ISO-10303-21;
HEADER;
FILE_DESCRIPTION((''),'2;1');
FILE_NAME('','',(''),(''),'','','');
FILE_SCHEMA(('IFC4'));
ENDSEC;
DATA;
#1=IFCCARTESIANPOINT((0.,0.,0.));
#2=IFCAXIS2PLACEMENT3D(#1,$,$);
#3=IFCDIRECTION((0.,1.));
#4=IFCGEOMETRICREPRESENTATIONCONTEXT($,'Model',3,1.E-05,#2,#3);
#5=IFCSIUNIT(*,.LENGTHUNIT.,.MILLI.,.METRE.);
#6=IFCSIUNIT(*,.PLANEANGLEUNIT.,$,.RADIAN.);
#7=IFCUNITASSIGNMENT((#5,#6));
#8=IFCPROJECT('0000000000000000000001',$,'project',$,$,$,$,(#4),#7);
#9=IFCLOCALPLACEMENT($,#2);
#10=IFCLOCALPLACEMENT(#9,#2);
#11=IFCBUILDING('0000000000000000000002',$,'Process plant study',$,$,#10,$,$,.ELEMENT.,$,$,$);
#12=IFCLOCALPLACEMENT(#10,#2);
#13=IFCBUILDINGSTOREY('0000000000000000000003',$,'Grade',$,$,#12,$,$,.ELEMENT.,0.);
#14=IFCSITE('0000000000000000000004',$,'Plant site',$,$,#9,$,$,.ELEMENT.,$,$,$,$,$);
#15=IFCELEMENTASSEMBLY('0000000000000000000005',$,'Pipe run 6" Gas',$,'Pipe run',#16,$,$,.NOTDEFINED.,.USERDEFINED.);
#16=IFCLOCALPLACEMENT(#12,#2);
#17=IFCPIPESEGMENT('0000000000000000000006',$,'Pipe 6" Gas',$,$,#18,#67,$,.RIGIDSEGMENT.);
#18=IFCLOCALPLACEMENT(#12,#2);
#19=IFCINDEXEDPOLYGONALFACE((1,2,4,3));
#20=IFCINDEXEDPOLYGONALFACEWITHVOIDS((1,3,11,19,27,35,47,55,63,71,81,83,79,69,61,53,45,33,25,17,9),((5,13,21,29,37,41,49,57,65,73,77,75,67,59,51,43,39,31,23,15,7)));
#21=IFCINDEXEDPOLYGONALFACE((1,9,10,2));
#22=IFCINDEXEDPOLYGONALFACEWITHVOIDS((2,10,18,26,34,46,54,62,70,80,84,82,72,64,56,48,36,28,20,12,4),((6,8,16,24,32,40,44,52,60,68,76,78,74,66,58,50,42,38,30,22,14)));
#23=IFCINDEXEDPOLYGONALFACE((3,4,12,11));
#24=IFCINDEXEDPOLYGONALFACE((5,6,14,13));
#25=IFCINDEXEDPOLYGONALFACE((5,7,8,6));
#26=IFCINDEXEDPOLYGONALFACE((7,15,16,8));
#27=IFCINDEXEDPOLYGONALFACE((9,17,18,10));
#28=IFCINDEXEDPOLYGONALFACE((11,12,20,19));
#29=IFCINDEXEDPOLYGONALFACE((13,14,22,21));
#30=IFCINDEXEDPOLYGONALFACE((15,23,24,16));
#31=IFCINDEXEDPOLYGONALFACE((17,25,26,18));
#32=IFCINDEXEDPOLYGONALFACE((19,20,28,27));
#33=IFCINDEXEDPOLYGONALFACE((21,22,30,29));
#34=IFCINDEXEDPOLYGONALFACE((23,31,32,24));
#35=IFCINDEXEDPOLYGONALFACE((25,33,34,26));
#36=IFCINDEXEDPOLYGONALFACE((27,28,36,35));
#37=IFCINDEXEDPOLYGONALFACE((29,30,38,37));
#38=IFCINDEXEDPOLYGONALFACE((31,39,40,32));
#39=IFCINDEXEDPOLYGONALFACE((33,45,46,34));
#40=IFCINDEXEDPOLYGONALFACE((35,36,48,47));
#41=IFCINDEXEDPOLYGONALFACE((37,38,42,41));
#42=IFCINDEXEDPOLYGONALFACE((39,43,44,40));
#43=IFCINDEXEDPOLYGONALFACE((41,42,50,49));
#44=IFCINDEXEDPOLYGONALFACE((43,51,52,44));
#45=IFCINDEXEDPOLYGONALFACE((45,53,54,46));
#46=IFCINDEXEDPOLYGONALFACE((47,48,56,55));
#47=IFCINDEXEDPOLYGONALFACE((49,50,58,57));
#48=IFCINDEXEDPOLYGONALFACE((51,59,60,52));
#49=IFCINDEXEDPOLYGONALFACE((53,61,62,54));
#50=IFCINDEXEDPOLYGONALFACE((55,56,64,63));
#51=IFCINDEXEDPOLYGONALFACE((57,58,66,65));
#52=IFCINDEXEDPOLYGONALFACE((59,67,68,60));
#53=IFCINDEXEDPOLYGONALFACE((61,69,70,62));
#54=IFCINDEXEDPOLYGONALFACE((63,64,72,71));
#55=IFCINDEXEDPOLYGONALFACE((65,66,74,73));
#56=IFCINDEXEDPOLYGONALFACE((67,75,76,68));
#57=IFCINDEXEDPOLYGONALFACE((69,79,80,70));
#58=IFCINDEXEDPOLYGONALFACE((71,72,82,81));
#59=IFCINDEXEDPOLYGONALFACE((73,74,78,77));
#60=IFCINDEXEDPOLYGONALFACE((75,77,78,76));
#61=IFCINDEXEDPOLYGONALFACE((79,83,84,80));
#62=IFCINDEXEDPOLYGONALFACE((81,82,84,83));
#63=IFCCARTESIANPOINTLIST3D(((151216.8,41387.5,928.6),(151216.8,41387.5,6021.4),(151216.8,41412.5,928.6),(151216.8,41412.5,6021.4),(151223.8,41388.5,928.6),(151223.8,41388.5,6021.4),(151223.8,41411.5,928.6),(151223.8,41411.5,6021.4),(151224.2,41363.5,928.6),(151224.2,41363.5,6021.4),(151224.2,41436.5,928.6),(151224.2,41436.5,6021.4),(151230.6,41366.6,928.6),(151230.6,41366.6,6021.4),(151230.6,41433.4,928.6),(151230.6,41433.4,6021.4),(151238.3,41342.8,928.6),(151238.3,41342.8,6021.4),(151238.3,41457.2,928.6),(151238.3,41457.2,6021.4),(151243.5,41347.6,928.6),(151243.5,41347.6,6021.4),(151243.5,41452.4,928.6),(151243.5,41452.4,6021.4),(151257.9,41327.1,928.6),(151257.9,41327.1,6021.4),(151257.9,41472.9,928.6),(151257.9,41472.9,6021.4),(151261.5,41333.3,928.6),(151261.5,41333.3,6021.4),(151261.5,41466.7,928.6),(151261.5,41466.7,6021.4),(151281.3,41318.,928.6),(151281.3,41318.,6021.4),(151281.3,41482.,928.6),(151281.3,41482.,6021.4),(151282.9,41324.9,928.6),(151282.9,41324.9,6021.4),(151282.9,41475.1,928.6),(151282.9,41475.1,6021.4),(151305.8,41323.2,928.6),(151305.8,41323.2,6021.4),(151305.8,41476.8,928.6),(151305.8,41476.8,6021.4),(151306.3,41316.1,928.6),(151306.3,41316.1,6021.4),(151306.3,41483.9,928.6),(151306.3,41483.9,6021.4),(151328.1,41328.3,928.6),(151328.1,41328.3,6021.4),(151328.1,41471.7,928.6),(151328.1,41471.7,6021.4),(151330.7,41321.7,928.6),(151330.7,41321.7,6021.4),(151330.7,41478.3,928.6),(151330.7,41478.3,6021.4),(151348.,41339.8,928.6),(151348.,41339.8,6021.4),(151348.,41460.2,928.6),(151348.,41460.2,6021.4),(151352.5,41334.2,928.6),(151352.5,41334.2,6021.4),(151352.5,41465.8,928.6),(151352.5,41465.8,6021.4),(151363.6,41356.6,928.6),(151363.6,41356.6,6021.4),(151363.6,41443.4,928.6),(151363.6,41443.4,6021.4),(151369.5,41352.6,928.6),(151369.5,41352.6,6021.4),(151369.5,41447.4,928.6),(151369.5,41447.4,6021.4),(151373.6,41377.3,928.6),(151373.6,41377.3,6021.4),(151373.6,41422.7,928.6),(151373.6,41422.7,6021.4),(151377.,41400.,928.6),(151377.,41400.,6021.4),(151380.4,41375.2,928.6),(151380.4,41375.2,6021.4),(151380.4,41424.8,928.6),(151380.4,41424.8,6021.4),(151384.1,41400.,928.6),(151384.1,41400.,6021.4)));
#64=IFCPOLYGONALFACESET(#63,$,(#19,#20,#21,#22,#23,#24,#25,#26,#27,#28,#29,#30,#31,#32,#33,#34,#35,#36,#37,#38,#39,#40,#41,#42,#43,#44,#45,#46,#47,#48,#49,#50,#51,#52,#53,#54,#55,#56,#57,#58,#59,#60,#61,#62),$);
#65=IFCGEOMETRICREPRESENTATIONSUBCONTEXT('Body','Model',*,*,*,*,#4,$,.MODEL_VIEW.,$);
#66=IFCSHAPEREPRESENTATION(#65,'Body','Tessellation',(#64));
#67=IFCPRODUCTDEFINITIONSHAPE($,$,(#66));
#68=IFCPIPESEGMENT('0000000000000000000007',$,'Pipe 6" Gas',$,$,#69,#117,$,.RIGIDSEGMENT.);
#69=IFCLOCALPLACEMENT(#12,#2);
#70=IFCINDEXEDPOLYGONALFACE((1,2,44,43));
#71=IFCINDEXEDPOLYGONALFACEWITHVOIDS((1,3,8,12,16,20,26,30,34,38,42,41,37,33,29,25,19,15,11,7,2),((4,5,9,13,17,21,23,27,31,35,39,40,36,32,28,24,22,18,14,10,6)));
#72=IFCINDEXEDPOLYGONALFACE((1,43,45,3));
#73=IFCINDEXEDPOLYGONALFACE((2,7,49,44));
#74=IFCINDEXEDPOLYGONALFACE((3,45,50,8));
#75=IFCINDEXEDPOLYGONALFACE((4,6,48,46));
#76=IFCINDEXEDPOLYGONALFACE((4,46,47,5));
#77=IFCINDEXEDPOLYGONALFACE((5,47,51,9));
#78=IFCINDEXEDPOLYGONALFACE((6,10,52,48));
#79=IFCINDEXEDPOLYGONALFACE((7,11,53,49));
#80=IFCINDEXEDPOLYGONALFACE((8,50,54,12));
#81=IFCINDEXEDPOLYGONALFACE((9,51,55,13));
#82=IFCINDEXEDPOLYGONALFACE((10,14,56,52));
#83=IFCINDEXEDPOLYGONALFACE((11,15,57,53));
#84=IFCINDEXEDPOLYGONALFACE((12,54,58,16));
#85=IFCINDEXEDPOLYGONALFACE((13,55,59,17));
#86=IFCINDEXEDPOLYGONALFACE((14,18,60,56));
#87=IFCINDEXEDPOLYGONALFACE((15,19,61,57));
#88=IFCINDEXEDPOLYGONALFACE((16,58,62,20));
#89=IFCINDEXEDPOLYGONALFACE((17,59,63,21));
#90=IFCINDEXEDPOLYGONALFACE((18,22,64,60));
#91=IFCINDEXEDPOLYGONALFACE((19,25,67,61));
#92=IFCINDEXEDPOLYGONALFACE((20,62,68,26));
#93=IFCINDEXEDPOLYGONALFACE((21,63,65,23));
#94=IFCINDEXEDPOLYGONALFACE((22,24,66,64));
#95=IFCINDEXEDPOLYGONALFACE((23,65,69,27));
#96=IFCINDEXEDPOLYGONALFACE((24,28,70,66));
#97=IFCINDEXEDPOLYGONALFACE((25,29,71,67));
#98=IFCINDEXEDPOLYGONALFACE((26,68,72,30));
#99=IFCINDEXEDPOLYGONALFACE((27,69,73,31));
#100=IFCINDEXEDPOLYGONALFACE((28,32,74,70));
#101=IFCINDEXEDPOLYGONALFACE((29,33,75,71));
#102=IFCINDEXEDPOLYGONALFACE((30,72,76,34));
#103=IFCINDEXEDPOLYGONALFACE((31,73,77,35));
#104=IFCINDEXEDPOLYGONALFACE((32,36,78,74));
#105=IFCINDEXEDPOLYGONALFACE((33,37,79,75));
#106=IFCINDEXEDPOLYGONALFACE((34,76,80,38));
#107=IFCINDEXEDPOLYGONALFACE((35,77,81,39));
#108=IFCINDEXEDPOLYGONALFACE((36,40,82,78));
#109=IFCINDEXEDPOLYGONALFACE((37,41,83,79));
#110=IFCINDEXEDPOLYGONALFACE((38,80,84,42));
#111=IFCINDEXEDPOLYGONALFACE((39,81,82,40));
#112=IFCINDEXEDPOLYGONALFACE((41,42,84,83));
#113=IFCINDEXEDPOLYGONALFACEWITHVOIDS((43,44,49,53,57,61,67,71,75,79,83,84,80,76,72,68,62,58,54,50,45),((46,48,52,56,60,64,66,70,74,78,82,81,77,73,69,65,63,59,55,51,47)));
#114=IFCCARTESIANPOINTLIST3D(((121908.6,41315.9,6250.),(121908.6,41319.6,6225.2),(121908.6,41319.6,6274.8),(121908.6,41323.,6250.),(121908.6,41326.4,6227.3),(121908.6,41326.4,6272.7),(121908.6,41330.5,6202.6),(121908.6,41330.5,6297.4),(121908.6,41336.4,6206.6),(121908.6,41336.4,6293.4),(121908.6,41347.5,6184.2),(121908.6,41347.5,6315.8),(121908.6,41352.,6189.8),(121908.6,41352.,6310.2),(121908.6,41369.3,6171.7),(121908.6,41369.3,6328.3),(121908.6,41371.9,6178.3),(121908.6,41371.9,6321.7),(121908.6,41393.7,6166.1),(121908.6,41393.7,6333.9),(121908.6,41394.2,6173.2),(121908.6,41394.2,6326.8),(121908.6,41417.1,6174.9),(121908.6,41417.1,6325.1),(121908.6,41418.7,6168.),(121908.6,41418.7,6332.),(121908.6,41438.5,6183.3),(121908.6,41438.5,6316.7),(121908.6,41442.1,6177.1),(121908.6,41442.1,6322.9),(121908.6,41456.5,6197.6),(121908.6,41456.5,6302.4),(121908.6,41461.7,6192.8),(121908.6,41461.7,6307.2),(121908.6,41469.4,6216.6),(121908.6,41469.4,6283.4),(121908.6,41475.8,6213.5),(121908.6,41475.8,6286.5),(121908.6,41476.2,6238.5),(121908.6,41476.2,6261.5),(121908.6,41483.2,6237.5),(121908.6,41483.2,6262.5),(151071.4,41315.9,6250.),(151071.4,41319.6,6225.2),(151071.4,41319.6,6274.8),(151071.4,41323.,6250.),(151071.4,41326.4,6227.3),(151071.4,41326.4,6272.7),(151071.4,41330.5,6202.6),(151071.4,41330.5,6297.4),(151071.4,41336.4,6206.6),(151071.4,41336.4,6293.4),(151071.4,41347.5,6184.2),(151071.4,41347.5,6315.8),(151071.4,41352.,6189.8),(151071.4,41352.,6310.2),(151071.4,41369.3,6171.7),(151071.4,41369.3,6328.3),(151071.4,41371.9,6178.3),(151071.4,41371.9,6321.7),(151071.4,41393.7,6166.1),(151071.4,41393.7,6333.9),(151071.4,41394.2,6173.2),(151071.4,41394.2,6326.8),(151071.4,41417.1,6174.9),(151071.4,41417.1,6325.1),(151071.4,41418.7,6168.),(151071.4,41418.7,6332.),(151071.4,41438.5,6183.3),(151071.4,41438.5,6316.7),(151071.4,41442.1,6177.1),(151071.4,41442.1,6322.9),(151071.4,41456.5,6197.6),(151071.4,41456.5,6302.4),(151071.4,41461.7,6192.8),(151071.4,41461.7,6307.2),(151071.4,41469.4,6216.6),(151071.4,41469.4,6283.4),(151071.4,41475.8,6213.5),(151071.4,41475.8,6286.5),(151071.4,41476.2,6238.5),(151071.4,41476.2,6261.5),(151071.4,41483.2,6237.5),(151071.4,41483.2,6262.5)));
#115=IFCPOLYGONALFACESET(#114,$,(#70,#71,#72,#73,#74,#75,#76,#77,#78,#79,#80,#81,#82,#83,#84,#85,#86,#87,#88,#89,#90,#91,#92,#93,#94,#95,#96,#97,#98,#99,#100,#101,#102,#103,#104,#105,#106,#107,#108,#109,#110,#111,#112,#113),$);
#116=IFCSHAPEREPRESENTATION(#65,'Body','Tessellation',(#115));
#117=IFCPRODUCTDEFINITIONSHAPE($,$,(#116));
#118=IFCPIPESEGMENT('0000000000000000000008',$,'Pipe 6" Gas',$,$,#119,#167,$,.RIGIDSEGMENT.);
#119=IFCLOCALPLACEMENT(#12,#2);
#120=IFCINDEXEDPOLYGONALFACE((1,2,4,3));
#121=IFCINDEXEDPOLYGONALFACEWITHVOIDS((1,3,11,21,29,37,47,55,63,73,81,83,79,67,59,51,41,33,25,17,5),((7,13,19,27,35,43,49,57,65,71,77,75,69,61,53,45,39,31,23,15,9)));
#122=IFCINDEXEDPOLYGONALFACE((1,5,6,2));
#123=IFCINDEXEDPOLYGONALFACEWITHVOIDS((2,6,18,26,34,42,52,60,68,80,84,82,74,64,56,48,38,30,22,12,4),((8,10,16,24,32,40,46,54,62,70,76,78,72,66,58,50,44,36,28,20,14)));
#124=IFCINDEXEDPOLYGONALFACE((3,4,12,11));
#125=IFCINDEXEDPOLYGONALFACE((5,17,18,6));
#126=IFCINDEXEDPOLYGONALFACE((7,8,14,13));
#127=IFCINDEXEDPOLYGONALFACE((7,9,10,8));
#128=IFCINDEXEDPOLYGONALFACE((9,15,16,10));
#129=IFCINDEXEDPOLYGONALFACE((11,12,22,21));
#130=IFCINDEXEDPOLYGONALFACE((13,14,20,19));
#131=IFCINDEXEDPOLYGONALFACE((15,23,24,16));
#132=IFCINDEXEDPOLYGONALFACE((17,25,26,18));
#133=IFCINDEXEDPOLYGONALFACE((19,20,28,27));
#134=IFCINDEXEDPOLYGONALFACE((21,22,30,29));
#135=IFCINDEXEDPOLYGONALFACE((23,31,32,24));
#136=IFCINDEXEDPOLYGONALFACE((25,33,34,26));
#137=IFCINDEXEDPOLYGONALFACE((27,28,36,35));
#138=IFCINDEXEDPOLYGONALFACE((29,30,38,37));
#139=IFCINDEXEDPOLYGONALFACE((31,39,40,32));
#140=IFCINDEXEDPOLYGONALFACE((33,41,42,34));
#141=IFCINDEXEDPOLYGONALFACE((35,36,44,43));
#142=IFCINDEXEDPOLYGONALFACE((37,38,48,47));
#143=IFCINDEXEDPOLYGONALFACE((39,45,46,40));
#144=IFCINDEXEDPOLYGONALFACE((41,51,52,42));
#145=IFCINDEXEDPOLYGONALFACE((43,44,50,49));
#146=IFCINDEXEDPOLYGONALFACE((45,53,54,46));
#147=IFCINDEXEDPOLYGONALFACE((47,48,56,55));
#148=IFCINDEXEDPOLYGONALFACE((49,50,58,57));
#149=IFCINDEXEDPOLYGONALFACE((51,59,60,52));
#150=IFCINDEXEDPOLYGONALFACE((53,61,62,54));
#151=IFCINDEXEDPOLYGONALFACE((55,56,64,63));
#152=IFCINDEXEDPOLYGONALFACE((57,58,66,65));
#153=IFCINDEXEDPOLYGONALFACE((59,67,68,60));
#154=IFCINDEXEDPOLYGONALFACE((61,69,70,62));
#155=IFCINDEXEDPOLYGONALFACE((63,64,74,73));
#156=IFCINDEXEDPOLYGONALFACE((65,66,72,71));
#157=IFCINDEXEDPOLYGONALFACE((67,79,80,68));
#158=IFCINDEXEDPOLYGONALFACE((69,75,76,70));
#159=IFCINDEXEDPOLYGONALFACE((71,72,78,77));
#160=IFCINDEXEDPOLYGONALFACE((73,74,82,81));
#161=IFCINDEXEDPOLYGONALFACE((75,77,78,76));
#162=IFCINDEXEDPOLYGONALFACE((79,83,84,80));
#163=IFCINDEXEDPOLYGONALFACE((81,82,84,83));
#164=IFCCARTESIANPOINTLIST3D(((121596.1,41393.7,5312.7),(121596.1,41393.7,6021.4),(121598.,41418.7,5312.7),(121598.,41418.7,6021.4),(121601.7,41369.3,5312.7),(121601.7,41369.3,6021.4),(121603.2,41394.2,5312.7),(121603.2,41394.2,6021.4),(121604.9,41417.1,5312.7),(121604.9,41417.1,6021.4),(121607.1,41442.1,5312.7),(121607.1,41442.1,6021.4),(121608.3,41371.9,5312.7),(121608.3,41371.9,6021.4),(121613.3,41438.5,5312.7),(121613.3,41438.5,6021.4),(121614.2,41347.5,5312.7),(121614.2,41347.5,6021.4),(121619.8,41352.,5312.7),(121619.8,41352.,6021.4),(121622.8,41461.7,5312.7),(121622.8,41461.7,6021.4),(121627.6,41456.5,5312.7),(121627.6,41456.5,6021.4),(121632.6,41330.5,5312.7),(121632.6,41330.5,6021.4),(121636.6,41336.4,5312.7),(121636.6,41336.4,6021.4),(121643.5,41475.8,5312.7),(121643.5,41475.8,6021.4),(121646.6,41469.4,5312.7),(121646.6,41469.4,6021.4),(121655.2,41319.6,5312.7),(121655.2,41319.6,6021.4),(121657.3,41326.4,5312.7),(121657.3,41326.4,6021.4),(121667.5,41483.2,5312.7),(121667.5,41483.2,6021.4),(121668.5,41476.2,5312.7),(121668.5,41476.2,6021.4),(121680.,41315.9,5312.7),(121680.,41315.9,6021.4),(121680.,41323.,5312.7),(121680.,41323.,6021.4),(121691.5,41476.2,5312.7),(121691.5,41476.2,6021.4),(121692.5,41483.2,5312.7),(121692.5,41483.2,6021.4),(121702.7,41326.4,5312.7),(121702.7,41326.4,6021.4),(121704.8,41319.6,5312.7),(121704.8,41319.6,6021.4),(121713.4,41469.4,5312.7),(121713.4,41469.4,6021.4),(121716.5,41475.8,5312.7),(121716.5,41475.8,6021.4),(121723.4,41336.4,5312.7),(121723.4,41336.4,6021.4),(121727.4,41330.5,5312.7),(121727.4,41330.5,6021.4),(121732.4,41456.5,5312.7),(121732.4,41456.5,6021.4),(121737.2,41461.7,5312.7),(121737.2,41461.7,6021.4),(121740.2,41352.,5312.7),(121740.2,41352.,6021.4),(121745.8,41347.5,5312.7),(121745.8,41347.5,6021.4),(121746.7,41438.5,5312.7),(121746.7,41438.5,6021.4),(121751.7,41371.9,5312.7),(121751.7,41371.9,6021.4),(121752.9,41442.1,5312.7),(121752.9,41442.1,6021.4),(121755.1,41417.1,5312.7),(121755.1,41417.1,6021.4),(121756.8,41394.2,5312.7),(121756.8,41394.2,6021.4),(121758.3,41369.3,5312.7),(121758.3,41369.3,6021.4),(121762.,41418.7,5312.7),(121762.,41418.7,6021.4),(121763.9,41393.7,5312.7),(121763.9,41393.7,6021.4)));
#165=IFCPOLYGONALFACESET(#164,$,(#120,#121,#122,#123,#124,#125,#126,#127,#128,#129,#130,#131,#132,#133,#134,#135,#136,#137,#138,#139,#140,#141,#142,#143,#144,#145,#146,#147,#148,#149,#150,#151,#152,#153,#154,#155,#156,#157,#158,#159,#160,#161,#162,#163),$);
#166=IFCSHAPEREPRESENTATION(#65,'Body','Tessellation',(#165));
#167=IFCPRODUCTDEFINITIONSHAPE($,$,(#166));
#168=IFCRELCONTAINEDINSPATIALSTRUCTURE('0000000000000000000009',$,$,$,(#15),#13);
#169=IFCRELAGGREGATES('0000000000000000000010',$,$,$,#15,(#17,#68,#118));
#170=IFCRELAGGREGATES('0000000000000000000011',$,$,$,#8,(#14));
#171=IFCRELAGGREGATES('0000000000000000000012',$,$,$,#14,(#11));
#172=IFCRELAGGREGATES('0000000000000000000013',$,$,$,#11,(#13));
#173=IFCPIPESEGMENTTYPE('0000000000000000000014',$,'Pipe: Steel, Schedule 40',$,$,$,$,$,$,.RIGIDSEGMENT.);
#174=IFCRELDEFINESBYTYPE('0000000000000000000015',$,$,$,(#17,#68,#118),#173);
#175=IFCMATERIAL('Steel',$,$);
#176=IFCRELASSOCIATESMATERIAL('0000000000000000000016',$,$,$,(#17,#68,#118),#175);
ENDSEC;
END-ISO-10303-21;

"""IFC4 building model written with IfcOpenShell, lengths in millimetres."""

from ifc_helpers import new_model, si_unit, direction, frame, origin, origin_with_axes, origin_2d, place, context, subcontext, project, spatial, hollow_circle, extrude, material, type_object, element, aggregate, save


model = new_model("IFC4")

# Units and contexts
model_context = context("Model", 3, precision=1e-05, world=origin(), true_north=direction((0.0, 1.0)))
body_context = subcontext(model_context, "Body", "Model", "MODEL_VIEW")
ifc_project = project(units=[si_unit("LENGTHUNIT", "METRE", prefix="MILLI"), si_unit("PLANEANGLEUNIT", "RADIAN")], contexts=[model_context])

# Site, building, storey
site_placement = place(None, origin())
site = spatial("IfcSite", under=ifc_project, at=site_placement, Name="Plant site", CompositionType="ELEMENT")
building_placement = place(site_placement, origin())
building = spatial("IfcBuilding", under=site, at=building_placement, Name="Process plant study", CompositionType="ELEMENT")
storey_placement = place(building_placement, origin())
storey = spatial("IfcBuildingStorey", under=building, at=storey_placement, Name="Grade", CompositionType="ELEMENT", Elevation=0.0)

# Shared definitions
ifc_material = material(Name="Steel")
pipe_segment_type = type_object("IfcPipeSegmentType", Name="Pipe: Steel, Schedule 40", PredefinedType="RIGIDSEGMENT")

# Element assembly, pipe segments
assembly_1_placement = place(storey_placement, origin_with_axes())
assembly_1 = element("IfcElementAssembly", 1, at=assembly_1_placement, inside=storey, Name="Pipe run 6\" Gas", ObjectType="Pipe run", AssemblyPlace="NOTDEFINED", PredefinedType="USERDEFINED")
pipe_segment_1_placement = place(storey_placement, origin_with_axes())
pipe_segment_1 = element("IfcPipeSegment", 2, at=pipe_segment_1_placement, type_object=pipe_segment_type, material=ifc_material, Name="Pipe 6\" Gas", PredefinedType="RIGIDSEGMENT", context=body_context, shape_type="SweptSolid", body=[
    extrude(hollow_circle(Radius=84.1, WallThickness=7.1, at=origin_2d()), frame((151300.0, 41400.0, 928.6), z_axis=(0.0, 0.0, 1.0), x_axis=(1.0, 0.0, 0.0)), (0.0, 0.0, 1.0), 5092.8),
])
pipe_segment_2_placement = place(storey_placement, origin_with_axes())
pipe_segment_2 = element("IfcPipeSegment", 3, at=pipe_segment_2_placement, type_object=pipe_segment_type, material=ifc_material, Name="Pipe 6\" Gas", PredefinedType="RIGIDSEGMENT", context=body_context, shape_type="SweptSolid", body=[
    extrude(hollow_circle(Radius=84.1, WallThickness=7.1, at=origin_2d()), frame((151071.4, 41400.0, 6250.0), z_axis=(-1.0, 0.0, 0.0), x_axis=(0.0, -1.0, 0.0)), (0.0, 0.0, 1.0), 29162.8),
])
pipe_segment_3_placement = place(storey_placement, origin_with_axes())
pipe_segment_3 = element("IfcPipeSegment", 4, at=pipe_segment_3_placement, type_object=pipe_segment_type, material=ifc_material, Name="Pipe 6\" Gas", PredefinedType="RIGIDSEGMENT", context=body_context, shape_type="SweptSolid", body=[
    extrude(hollow_circle(Radius=84.1, WallThickness=7.1, at=origin_2d()), frame((121680.0, 41400.0, 6021.4), z_axis=(0.0, 0.0, -1.0), x_axis=(0.0, -1.0, 0.0)), (0.0, 0.0, 1.0), 708.7),
])

aggregate(assembly_1, [pipe_segment_1, pipe_segment_2, pipe_segment_3])

save(model, "model.ifc")
